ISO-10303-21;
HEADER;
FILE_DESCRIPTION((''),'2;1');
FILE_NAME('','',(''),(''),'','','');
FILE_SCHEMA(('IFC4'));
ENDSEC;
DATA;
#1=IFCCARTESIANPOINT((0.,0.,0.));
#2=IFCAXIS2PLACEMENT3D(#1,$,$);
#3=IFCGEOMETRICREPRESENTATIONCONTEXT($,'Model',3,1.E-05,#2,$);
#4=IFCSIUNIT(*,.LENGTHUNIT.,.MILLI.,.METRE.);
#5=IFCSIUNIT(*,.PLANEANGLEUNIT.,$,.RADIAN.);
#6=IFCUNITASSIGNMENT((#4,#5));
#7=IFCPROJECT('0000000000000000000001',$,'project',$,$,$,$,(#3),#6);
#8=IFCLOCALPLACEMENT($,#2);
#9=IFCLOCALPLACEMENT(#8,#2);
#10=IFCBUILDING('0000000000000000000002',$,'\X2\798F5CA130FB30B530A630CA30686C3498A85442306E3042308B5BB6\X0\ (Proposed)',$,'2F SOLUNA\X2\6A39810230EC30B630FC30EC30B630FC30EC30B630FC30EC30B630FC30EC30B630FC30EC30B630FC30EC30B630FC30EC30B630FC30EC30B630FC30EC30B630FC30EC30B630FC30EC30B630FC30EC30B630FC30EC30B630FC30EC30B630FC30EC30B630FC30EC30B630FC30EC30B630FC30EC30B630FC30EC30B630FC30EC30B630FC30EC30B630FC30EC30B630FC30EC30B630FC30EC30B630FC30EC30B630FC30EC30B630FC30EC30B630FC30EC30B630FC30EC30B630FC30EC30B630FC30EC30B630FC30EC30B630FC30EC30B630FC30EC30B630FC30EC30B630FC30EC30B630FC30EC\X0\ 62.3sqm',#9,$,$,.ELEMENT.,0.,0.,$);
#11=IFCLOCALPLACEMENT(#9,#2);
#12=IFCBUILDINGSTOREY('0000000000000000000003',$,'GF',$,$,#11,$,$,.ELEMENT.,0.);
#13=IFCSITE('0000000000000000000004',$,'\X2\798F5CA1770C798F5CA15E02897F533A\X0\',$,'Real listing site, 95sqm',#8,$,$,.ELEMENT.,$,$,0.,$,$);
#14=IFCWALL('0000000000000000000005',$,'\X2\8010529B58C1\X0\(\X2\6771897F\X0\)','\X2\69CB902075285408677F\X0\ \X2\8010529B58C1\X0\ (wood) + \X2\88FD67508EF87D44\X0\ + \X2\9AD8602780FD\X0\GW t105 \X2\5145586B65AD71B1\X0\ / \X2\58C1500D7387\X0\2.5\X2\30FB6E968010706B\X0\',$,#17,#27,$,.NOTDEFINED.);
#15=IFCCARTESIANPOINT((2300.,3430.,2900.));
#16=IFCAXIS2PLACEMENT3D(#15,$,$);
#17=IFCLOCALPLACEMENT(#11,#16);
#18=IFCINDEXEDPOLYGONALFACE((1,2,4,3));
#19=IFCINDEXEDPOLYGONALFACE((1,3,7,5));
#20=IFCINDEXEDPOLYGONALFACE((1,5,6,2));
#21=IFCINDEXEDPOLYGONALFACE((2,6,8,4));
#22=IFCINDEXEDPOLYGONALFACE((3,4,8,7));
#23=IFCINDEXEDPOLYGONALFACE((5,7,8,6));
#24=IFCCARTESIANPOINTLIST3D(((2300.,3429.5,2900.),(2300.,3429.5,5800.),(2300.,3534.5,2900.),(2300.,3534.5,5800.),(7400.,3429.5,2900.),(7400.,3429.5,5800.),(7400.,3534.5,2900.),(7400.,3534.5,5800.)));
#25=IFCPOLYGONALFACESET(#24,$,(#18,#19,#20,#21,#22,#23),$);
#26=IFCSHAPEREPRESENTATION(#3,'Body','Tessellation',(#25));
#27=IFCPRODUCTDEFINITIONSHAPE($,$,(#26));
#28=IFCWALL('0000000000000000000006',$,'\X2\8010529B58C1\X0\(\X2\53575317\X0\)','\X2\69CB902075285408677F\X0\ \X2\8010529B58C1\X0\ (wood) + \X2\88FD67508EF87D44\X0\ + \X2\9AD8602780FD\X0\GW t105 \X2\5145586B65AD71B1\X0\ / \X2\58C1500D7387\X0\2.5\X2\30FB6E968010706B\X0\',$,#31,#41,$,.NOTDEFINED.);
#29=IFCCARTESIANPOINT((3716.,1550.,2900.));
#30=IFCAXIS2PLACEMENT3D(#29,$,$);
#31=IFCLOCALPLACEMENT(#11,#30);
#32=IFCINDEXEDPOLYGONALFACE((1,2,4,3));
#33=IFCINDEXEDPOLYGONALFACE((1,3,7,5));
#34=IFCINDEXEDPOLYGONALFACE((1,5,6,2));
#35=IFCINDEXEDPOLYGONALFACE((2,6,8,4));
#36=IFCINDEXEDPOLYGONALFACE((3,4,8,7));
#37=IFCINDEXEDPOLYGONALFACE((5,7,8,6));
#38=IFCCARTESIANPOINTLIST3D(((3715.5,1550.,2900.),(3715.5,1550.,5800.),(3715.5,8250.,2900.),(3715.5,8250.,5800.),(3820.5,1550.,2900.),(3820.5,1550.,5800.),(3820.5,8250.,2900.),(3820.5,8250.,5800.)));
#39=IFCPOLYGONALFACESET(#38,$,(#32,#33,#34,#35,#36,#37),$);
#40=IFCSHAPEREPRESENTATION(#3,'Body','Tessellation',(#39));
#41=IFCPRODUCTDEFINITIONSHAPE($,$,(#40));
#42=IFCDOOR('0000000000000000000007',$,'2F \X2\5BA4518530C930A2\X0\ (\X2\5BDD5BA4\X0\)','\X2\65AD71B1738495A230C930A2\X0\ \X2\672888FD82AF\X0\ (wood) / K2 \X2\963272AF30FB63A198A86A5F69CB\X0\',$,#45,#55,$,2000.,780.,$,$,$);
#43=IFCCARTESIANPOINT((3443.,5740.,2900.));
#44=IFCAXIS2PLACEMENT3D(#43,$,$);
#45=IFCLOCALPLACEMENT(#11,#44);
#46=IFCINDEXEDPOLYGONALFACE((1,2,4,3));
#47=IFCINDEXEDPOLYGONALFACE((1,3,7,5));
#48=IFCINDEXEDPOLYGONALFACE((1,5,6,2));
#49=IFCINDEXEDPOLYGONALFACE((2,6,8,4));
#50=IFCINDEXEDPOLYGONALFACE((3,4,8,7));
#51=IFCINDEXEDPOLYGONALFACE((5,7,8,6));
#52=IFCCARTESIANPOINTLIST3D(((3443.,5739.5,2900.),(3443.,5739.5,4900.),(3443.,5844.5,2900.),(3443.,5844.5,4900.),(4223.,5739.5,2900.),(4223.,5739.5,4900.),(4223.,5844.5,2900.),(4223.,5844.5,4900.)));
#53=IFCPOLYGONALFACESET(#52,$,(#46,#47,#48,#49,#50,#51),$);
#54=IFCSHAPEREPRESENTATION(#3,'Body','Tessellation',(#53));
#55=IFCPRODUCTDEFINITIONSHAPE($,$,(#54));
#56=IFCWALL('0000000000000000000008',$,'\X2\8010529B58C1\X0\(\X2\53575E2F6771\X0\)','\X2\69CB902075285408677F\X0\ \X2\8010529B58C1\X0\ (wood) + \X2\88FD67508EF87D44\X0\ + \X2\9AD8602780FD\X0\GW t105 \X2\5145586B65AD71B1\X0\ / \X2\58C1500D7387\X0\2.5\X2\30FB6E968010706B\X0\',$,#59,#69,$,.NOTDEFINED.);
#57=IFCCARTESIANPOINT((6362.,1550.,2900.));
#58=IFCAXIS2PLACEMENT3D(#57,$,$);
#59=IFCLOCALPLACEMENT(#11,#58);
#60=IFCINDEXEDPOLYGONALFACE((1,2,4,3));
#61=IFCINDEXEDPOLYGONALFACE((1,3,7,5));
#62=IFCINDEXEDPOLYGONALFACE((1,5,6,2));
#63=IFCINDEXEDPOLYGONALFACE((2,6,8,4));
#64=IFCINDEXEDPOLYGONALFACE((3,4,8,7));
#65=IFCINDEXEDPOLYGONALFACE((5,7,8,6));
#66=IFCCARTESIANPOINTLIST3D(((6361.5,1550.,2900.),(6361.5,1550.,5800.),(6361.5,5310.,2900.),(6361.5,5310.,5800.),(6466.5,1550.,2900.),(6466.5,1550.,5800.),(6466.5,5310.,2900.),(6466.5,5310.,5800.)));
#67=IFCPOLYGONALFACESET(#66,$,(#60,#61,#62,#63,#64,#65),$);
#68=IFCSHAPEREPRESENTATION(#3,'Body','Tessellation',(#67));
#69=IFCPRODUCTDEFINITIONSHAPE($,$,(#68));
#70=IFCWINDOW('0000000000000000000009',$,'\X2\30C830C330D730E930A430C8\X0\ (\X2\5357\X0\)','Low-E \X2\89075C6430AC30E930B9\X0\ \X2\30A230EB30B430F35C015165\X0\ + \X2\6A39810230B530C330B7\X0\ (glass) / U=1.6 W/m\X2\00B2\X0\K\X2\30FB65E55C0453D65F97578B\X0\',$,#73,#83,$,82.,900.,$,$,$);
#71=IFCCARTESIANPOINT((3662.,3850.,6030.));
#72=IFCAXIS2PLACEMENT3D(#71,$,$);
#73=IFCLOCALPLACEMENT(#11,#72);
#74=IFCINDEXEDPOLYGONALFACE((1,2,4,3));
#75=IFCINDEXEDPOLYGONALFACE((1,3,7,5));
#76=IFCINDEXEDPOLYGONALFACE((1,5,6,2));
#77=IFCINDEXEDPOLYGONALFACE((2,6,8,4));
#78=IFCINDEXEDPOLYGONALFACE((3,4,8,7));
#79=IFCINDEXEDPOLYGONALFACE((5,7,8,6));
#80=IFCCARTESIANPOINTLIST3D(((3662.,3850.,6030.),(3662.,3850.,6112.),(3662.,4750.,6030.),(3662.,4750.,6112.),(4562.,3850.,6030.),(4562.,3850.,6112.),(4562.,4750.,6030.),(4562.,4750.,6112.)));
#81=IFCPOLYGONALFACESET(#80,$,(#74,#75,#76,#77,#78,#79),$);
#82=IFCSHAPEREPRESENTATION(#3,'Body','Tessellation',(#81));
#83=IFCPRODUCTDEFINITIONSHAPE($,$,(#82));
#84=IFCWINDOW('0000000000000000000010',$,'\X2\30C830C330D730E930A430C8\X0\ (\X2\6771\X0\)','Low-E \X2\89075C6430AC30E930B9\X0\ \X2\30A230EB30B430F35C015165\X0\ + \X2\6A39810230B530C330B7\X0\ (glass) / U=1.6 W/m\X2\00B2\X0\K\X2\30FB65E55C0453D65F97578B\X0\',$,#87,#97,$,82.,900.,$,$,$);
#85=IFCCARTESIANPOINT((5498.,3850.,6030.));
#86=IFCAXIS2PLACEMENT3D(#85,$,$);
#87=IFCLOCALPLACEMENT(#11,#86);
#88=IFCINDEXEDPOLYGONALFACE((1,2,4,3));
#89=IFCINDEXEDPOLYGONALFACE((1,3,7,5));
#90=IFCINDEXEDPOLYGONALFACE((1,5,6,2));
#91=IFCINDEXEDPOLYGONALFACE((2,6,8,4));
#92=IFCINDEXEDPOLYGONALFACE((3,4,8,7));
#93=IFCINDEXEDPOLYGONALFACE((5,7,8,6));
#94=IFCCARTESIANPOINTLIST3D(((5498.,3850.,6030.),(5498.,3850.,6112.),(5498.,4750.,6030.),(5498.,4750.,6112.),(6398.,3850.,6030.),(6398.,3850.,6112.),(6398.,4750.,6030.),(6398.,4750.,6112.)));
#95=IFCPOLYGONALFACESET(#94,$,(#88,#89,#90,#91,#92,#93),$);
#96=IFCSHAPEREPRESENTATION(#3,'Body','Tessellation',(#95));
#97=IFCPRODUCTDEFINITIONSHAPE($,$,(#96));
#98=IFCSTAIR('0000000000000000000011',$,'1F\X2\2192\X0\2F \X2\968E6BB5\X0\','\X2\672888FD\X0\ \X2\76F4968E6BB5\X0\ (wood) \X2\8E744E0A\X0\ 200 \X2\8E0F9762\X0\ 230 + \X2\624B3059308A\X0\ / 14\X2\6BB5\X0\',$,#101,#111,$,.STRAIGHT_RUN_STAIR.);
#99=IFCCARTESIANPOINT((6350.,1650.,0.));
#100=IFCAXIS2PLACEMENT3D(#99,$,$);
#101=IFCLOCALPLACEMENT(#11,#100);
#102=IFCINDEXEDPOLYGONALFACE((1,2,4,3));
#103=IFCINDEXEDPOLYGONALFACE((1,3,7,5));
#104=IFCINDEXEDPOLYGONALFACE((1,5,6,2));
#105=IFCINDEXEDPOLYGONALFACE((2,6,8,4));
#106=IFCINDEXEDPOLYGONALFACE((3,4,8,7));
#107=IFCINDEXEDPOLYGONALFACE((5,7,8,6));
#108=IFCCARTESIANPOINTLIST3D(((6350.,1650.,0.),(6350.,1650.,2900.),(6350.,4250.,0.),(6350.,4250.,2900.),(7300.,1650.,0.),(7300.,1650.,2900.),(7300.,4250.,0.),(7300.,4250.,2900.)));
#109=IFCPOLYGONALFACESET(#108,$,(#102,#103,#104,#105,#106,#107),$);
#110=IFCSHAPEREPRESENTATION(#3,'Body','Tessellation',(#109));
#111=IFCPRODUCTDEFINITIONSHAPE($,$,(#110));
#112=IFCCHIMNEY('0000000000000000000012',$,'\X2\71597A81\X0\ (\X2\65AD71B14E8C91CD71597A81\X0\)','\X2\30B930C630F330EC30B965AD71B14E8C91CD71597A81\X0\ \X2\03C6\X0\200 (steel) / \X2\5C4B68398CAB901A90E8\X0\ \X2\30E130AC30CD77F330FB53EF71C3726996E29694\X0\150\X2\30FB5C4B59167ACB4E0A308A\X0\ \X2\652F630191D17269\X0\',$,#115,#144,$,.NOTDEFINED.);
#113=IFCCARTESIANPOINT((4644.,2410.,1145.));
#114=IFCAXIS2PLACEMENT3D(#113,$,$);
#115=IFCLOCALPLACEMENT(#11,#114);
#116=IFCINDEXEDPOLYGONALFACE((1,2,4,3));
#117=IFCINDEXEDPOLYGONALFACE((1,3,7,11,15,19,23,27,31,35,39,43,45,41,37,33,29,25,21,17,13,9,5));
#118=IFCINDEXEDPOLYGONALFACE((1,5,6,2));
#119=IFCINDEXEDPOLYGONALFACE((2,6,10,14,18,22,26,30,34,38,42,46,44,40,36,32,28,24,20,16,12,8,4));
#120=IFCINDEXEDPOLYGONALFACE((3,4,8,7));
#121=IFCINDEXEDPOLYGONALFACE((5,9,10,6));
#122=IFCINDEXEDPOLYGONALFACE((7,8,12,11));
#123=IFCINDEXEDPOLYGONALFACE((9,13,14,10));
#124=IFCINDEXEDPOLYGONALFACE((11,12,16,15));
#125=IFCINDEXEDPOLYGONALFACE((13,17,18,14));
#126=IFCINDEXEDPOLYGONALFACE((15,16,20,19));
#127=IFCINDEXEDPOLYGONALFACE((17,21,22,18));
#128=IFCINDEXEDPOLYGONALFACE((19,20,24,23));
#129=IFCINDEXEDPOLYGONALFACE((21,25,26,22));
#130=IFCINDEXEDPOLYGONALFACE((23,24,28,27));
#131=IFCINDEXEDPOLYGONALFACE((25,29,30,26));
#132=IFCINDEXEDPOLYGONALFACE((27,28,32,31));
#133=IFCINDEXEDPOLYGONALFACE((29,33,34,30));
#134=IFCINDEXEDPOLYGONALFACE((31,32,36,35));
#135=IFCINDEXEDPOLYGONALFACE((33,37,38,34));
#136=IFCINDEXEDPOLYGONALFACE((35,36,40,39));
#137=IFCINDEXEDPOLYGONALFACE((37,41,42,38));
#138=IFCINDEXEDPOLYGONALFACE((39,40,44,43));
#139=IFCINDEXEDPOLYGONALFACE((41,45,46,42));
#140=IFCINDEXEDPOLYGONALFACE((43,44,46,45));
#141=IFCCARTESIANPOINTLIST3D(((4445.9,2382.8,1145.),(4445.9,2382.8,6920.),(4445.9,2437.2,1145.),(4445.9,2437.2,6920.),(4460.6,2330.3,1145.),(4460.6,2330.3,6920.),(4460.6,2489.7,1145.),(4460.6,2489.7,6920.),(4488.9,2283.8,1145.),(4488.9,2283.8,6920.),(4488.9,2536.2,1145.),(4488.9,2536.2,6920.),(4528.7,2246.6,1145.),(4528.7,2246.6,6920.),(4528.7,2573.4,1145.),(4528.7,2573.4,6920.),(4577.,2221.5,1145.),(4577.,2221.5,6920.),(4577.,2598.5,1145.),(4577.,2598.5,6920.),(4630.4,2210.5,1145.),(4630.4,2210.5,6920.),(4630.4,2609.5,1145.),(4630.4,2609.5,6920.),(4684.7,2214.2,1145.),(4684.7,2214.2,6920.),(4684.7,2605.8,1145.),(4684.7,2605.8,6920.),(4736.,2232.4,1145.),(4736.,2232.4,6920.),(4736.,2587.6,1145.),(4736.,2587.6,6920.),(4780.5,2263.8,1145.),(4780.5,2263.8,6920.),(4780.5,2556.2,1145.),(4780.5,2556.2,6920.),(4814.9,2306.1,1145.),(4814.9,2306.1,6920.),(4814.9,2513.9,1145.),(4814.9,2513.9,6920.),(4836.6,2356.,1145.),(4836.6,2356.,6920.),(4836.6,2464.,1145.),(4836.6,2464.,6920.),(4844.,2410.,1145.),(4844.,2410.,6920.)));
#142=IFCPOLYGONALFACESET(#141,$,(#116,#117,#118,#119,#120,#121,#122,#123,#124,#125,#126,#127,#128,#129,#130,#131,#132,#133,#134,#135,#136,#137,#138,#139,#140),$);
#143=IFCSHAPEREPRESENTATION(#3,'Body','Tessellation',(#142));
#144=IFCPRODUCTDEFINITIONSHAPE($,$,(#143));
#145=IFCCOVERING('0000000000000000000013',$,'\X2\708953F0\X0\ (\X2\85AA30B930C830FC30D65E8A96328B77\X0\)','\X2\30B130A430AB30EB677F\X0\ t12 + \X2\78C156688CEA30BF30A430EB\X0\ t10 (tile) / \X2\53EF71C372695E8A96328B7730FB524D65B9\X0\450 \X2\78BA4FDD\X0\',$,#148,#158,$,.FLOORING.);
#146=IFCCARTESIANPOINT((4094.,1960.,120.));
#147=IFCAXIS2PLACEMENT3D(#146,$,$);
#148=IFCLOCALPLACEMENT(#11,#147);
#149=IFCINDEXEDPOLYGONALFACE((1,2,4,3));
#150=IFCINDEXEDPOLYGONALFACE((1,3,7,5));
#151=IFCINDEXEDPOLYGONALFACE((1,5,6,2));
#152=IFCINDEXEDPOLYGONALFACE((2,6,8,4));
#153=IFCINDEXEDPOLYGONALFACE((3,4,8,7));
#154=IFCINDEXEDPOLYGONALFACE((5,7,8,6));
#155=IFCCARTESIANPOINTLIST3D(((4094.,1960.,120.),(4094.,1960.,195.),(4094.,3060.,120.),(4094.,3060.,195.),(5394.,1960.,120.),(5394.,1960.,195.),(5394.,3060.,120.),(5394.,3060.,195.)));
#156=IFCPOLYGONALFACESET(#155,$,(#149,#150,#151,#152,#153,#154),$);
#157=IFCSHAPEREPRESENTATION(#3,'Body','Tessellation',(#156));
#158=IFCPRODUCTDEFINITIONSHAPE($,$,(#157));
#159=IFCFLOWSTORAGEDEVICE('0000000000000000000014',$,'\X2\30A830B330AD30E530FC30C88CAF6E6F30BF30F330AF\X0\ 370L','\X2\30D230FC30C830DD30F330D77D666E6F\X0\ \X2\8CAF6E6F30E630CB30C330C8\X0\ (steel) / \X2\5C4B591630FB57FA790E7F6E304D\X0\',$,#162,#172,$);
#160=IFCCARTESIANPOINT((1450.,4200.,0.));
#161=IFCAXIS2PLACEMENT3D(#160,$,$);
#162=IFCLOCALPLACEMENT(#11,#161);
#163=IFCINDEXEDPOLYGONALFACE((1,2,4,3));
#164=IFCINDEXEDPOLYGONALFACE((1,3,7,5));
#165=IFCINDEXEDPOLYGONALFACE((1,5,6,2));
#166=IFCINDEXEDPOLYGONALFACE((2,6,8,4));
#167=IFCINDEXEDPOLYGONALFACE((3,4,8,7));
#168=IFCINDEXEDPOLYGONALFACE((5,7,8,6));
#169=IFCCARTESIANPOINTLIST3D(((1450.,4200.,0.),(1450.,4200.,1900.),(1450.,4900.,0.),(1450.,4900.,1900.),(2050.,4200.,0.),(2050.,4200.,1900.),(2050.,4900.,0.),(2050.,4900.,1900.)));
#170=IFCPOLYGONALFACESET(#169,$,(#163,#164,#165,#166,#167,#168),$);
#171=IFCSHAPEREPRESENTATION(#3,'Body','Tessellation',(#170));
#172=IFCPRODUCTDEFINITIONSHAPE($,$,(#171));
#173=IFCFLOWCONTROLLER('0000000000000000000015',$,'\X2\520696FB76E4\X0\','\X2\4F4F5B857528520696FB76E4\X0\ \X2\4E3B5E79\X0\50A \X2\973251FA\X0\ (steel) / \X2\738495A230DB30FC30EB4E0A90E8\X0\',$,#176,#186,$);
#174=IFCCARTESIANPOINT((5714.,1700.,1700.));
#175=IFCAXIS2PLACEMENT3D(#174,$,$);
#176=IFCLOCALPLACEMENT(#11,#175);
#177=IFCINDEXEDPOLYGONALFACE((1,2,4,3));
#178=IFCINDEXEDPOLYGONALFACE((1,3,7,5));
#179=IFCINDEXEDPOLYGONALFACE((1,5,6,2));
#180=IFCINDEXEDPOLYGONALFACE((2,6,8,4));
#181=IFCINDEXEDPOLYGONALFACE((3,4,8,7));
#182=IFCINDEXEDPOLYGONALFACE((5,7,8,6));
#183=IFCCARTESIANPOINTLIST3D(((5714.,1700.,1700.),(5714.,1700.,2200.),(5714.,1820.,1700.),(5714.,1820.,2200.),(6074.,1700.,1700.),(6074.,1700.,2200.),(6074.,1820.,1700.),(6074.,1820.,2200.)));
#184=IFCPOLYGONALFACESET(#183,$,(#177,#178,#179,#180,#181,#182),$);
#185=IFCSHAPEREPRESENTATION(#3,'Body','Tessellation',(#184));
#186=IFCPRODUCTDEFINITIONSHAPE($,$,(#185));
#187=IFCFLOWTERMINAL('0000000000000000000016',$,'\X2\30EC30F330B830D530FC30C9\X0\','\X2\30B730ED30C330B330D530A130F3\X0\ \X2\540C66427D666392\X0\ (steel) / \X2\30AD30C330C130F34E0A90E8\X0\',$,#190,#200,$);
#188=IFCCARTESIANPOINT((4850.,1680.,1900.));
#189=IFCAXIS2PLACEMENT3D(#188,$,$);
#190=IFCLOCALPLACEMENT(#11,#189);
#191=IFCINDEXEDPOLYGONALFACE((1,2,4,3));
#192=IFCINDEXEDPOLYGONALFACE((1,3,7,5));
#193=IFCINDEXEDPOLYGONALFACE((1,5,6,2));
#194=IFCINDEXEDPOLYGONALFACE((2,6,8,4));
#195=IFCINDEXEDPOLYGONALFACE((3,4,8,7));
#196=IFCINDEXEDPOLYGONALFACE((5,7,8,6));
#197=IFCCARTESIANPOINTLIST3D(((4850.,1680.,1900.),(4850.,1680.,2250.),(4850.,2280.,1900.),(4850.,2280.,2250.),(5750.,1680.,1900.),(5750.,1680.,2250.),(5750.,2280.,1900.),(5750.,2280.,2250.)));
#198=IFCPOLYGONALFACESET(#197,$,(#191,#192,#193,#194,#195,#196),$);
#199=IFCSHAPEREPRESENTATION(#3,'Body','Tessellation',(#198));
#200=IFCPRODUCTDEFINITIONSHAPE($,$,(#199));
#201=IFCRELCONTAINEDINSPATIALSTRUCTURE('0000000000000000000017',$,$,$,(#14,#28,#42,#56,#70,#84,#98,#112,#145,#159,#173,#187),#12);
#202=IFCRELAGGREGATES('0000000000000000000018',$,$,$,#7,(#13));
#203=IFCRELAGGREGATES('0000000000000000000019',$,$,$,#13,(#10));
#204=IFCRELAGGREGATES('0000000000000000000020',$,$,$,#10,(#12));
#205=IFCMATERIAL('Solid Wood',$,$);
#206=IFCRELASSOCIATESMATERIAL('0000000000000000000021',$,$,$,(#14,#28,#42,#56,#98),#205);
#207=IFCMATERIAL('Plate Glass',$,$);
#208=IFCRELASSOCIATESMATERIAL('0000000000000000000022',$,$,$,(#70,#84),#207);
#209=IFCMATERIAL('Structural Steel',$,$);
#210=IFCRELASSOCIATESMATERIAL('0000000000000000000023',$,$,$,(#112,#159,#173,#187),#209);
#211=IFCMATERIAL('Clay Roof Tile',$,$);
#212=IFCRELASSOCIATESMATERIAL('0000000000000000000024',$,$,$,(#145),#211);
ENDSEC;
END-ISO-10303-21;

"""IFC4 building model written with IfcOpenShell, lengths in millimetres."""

from ifc_helpers import new_model, si_unit, frame, frame_2d, origin, origin_2d, place, context, project, spatial, rectangle, circle, extrude, material, element, fill, save


model = new_model("IFC4")

# Units and contexts
model_context = context("Model", 3, precision=1e-05, world=origin())
ifc_project = project(units=[si_unit("LENGTHUNIT", "METRE", prefix="MILLI"), si_unit("PLANEANGLEUNIT", "RADIAN")], contexts=[model_context])

# Site, building, storey
site_placement = place(None, origin())
site = spatial("IfcSite", under=ifc_project, at=site_placement, Name="福岡県福岡市西区", ObjectType="Real listing site, 95sqm", CompositionType="ELEMENT", RefElevation=0.0)
building_placement = place(site_placement, origin())
building = spatial("IfcBuilding", under=site, at=building_placement, Name="福岡・サウナと水風呂のある家 (Proposed)", ObjectType="2F SOLUNA樹脂レザーレザーレザーレザーレザーレザーレザーレザーレザーレザーレザーレザーレザーレザーレザーレザーレザーレザーレザーレザーレザーレザーレザーレザーレザーレザーレザーレザーレザーレザーレザーレザーレザーレザーレザーレザーレザーレ 62.3sqm", CompositionType="ELEMENT", ElevationOfRefHeight=0.0, ElevationOfTerrain=0.0)
storey_placement = place(building_placement, origin())
storey = spatial("IfcBuildingStorey", under=building, at=storey_placement, Name="GF", CompositionType="ELEMENT", Elevation=0.0)

# Shared definitions
ifc_material_1 = material(Name="Solid Wood")

# Wall
wall_1_placement = place(storey_placement, frame((2300.0, 3430.0, 2900.0)))
element("IfcWall", 1, at=wall_1_placement, inside=storey, material=ifc_material_1, Name="耐力壁(東西)", Description="構造用合板 耐力壁 (wood) + 製材軸組 + 高性能GW t105 充填断熱 / 壁倍率2.5・準耐火", PredefinedType="NOTDEFINED", context=model_context, shape_type="SweptSolid", body=[
    extrude(rectangle(XDim=5100.0, YDim=105.0, at=frame_2d((2550.0, 52.0))), frame((2300.0, 3430.0, 2900.0)), (0.0, 0.0, 1.0), 2900.0),
])

# Wall, opening, door
wall_2_placement = place(storey_placement, frame((3716.0, 1550.0, 2900.0)))
wall_2 = element("IfcWall", 2, at=wall_2_placement, inside=storey, material=ifc_material_1, Name="耐力壁(南北)", Description="構造用合板 耐力壁 (wood) + 製材軸組 + 高性能GW t105 充填断熱 / 壁倍率2.5・準耐火", PredefinedType="NOTDEFINED", context=model_context, shape_type="SweptSolid", body=[
    extrude(rectangle(XDim=105.0, YDim=6700.0, at=frame_2d((52.0, 3350.0))), frame((3716.0, 1550.0, 2900.0)), (0.0, 0.0, 1.0), 2900.0),
])
opening_placement = place(storey_placement, frame((3443.0, 5740.0, 2900.0)))
opening = element("IfcOpeningElement", 3, at=opening_placement, cuts=wall_2, PredefinedType="NOTDEFINED", context=model_context, shape_type="SweptSolid", body=[
    extrude(rectangle(XDim=780.0, YDim=105.0, at=frame_2d((390.0, 52.0))), frame((3443.0, 5740.0, 2900.0)), (0.0, 0.0, 1.0), 2000.0),
])
door_placement = place(storey_placement, frame((3443.0, 5740.0, 2900.0)))
door = element("IfcDoor", 4, at=door_placement, inside=storey, material=ifc_material_1, Name="2F 室内ドア (寝室)", Description="断熱玄関ドア 木製芯 (wood) / K2 防犯・採風機構", OverallHeight=2000.0, OverallWidth=780.0, context=model_context, shape_type="SweptSolid", body=[
    extrude(rectangle(XDim=780.0, YDim=105.0, at=frame_2d((390.0, 52.0))), frame((3443.0, 5740.0, 2900.0)), (0.0, 0.0, 1.0), 2000.0),
])
fill(opening, door)

# Wall
wall_3_placement = place(storey_placement, frame((6362.0, 1550.0, 2900.0)))
element("IfcWall", 5, at=wall_3_placement, inside=storey, material=ifc_material_1, Name="耐力壁(南帯東)", Description="構造用合板 耐力壁 (wood) + 製材軸組 + 高性能GW t105 充填断熱 / 壁倍率2.5・準耐火", PredefinedType="NOTDEFINED", context=model_context, shape_type="SweptSolid", body=[
    extrude(rectangle(XDim=105.0, YDim=3760.0, at=frame_2d((52.0, 1880.0))), frame((6362.0, 1550.0, 2900.0)), (0.0, 0.0, 1.0), 2900.0),
])

# Windows
ifc_material_2 = material(Name="Plate Glass")
window_1_placement = place(storey_placement, frame((3662.0, 3850.0, 6030.0)))
element("IfcWindow", 6, at=window_1_placement, inside=storey, material=ifc_material_2, Name="トップライト (南)", Description="Low-E 複層ガラス アルゴン封入 + 樹脂サッシ (glass) / U=1.6 W/m²K・日射取得型", OverallHeight=82.0, OverallWidth=900.0, context=model_context, shape_type="SweptSolid", body=[
    extrude(rectangle(XDim=900.0, YDim=900.0, at=frame_2d((450.0, 450.0))), frame((3662.0, 3850.0, 6030.0)), (0.0, 0.0, 1.0), 82.0),
])
window_2_placement = place(storey_placement, frame((5498.0, 3850.0, 6030.0)))
element("IfcWindow", 7, at=window_2_placement, inside=storey, material=ifc_material_2, Name="トップライト (東)", Description="Low-E 複層ガラス アルゴン封入 + 樹脂サッシ (glass) / U=1.6 W/m²K・日射取得型", OverallHeight=82.0, OverallWidth=900.0, context=model_context, shape_type="SweptSolid", body=[
    extrude(rectangle(XDim=900.0, YDim=900.0, at=frame_2d((450.0, 450.0))), frame((5498.0, 3850.0, 6030.0)), (0.0, 0.0, 1.0), 82.0),
])

# Stair
stair_placement = place(storey_placement, frame((6350.0, 1650.0, 0.0)))
element("IfcStair", 8, at=stair_placement, inside=storey, material=ifc_material_1, Name="1F→2F 階段", Description="木製 直階段 (wood) 蹴上 200 踏面 230 + 手すり / 14段", PredefinedType="STRAIGHT_RUN_STAIR", context=model_context, shape_type="SweptSolid", body=[
    extrude(rectangle(XDim=950.0, YDim=2600.0, at=frame_2d((475.0, 1300.0))), frame((6350.0, 1650.0, 0.0)), (0.0, 0.0, 1.0), 2900.0),
])

# Chimney
ifc_material_3 = material(Name="Structural Steel")
chimney_placement = place(storey_placement, frame((4644.0, 2410.0, 1145.0)))
element("IfcChimney", 9, at=chimney_placement, inside=storey, material=ifc_material_3, Name="煙突 (断熱二重煙突)", Description="ステンレス断熱二重煙突 φ200 (steel) / 屋根貫通部 メガネ石・可燃物離隔150・屋外立上り 支持金物", PredefinedType="NOTDEFINED", context=model_context, shape_type="SweptSolid", body=[
    extrude(circle(Radius=200.0, at=origin_2d()), frame((4644.0, 2410.0, 1145.0)), (0.0, 0.0, 1.0), 5775.0),
])

# Covering
ifc_material_4 = material(Name="Clay Roof Tile")
covering_placement = place(storey_placement, frame((4094.0, 1960.0, 120.0)))
element("IfcCovering", 10, at=covering_placement, inside=storey, material=ifc_material_4, Name="炉台 (薪ストーブ床防護)", Description="ケイカル板 t12 + 磁器質タイル t10 (tile) / 可燃物床防護・前方450 確保", PredefinedType="FLOORING", context=model_context, shape_type="SweptSolid", body=[
    extrude(rectangle(XDim=1300.0, YDim=1100.0, at=frame_2d((650.0, 550.0))), frame((4094.0, 1960.0, 120.0)), (0.0, 0.0, 1.0), 75.0),
])

# Flow storage device
flow_storage_device_placement = place(storey_placement, frame((1450.0, 4200.0, 0.0)))
element("IfcFlowStorageDevice", 11, at=flow_storage_device_placement, inside=storey, material=ifc_material_3, Name="エコキュート貯湯タンク 370L", Description="ヒートポンプ給湯 貯湯ユニット (steel) / 屋外・基礎置き", context=model_context, shape_type="SweptSolid", body=[
    extrude(rectangle(XDim=600.0, YDim=700.0, at=frame_2d((300.0, 350.0))), frame((1450.0, 4200.0, 0.0)), (0.0, 0.0, 1.0), 1900.0),
])

# Flow controller
flow_controller_placement = place(storey_placement, frame((5714.0, 1700.0, 1700.0)))
element("IfcFlowController", 12, at=flow_controller_placement, inside=storey, material=ifc_material_3, Name="分電盤", Description="住宅用分電盤 主幹50A 露出 (steel) / 玄関ホール上部", context=model_context, shape_type="SweptSolid", body=[
    extrude(rectangle(XDim=360.0, YDim=120.0, at=frame_2d((180.0, 60.0))), frame((5714.0, 1700.0, 1700.0)), (0.0, 0.0, 1.0), 500.0),
])

# Flow terminal
flow_terminal_1_placement = place(storey_placement, frame((4850.0, 1680.0, 1900.0)))
element("IfcFlowTerminal", 13, at=flow_terminal_1_placement, inside=storey, material=ifc_material_3, Name="レンジフード", Description="シロッコファン 同時給排 (steel) / キッチン上部", context=model_context, shape_type="SweptSolid", body=[
    extrude(rectangle(XDim=900.0, YDim=600.0, at=frame_2d((450.0, 300.0))), frame((4850.0, 1680.0, 1900.0)), (0.0, 0.0, 1.0), 350.0),
])

save(model, "model.ifc")
